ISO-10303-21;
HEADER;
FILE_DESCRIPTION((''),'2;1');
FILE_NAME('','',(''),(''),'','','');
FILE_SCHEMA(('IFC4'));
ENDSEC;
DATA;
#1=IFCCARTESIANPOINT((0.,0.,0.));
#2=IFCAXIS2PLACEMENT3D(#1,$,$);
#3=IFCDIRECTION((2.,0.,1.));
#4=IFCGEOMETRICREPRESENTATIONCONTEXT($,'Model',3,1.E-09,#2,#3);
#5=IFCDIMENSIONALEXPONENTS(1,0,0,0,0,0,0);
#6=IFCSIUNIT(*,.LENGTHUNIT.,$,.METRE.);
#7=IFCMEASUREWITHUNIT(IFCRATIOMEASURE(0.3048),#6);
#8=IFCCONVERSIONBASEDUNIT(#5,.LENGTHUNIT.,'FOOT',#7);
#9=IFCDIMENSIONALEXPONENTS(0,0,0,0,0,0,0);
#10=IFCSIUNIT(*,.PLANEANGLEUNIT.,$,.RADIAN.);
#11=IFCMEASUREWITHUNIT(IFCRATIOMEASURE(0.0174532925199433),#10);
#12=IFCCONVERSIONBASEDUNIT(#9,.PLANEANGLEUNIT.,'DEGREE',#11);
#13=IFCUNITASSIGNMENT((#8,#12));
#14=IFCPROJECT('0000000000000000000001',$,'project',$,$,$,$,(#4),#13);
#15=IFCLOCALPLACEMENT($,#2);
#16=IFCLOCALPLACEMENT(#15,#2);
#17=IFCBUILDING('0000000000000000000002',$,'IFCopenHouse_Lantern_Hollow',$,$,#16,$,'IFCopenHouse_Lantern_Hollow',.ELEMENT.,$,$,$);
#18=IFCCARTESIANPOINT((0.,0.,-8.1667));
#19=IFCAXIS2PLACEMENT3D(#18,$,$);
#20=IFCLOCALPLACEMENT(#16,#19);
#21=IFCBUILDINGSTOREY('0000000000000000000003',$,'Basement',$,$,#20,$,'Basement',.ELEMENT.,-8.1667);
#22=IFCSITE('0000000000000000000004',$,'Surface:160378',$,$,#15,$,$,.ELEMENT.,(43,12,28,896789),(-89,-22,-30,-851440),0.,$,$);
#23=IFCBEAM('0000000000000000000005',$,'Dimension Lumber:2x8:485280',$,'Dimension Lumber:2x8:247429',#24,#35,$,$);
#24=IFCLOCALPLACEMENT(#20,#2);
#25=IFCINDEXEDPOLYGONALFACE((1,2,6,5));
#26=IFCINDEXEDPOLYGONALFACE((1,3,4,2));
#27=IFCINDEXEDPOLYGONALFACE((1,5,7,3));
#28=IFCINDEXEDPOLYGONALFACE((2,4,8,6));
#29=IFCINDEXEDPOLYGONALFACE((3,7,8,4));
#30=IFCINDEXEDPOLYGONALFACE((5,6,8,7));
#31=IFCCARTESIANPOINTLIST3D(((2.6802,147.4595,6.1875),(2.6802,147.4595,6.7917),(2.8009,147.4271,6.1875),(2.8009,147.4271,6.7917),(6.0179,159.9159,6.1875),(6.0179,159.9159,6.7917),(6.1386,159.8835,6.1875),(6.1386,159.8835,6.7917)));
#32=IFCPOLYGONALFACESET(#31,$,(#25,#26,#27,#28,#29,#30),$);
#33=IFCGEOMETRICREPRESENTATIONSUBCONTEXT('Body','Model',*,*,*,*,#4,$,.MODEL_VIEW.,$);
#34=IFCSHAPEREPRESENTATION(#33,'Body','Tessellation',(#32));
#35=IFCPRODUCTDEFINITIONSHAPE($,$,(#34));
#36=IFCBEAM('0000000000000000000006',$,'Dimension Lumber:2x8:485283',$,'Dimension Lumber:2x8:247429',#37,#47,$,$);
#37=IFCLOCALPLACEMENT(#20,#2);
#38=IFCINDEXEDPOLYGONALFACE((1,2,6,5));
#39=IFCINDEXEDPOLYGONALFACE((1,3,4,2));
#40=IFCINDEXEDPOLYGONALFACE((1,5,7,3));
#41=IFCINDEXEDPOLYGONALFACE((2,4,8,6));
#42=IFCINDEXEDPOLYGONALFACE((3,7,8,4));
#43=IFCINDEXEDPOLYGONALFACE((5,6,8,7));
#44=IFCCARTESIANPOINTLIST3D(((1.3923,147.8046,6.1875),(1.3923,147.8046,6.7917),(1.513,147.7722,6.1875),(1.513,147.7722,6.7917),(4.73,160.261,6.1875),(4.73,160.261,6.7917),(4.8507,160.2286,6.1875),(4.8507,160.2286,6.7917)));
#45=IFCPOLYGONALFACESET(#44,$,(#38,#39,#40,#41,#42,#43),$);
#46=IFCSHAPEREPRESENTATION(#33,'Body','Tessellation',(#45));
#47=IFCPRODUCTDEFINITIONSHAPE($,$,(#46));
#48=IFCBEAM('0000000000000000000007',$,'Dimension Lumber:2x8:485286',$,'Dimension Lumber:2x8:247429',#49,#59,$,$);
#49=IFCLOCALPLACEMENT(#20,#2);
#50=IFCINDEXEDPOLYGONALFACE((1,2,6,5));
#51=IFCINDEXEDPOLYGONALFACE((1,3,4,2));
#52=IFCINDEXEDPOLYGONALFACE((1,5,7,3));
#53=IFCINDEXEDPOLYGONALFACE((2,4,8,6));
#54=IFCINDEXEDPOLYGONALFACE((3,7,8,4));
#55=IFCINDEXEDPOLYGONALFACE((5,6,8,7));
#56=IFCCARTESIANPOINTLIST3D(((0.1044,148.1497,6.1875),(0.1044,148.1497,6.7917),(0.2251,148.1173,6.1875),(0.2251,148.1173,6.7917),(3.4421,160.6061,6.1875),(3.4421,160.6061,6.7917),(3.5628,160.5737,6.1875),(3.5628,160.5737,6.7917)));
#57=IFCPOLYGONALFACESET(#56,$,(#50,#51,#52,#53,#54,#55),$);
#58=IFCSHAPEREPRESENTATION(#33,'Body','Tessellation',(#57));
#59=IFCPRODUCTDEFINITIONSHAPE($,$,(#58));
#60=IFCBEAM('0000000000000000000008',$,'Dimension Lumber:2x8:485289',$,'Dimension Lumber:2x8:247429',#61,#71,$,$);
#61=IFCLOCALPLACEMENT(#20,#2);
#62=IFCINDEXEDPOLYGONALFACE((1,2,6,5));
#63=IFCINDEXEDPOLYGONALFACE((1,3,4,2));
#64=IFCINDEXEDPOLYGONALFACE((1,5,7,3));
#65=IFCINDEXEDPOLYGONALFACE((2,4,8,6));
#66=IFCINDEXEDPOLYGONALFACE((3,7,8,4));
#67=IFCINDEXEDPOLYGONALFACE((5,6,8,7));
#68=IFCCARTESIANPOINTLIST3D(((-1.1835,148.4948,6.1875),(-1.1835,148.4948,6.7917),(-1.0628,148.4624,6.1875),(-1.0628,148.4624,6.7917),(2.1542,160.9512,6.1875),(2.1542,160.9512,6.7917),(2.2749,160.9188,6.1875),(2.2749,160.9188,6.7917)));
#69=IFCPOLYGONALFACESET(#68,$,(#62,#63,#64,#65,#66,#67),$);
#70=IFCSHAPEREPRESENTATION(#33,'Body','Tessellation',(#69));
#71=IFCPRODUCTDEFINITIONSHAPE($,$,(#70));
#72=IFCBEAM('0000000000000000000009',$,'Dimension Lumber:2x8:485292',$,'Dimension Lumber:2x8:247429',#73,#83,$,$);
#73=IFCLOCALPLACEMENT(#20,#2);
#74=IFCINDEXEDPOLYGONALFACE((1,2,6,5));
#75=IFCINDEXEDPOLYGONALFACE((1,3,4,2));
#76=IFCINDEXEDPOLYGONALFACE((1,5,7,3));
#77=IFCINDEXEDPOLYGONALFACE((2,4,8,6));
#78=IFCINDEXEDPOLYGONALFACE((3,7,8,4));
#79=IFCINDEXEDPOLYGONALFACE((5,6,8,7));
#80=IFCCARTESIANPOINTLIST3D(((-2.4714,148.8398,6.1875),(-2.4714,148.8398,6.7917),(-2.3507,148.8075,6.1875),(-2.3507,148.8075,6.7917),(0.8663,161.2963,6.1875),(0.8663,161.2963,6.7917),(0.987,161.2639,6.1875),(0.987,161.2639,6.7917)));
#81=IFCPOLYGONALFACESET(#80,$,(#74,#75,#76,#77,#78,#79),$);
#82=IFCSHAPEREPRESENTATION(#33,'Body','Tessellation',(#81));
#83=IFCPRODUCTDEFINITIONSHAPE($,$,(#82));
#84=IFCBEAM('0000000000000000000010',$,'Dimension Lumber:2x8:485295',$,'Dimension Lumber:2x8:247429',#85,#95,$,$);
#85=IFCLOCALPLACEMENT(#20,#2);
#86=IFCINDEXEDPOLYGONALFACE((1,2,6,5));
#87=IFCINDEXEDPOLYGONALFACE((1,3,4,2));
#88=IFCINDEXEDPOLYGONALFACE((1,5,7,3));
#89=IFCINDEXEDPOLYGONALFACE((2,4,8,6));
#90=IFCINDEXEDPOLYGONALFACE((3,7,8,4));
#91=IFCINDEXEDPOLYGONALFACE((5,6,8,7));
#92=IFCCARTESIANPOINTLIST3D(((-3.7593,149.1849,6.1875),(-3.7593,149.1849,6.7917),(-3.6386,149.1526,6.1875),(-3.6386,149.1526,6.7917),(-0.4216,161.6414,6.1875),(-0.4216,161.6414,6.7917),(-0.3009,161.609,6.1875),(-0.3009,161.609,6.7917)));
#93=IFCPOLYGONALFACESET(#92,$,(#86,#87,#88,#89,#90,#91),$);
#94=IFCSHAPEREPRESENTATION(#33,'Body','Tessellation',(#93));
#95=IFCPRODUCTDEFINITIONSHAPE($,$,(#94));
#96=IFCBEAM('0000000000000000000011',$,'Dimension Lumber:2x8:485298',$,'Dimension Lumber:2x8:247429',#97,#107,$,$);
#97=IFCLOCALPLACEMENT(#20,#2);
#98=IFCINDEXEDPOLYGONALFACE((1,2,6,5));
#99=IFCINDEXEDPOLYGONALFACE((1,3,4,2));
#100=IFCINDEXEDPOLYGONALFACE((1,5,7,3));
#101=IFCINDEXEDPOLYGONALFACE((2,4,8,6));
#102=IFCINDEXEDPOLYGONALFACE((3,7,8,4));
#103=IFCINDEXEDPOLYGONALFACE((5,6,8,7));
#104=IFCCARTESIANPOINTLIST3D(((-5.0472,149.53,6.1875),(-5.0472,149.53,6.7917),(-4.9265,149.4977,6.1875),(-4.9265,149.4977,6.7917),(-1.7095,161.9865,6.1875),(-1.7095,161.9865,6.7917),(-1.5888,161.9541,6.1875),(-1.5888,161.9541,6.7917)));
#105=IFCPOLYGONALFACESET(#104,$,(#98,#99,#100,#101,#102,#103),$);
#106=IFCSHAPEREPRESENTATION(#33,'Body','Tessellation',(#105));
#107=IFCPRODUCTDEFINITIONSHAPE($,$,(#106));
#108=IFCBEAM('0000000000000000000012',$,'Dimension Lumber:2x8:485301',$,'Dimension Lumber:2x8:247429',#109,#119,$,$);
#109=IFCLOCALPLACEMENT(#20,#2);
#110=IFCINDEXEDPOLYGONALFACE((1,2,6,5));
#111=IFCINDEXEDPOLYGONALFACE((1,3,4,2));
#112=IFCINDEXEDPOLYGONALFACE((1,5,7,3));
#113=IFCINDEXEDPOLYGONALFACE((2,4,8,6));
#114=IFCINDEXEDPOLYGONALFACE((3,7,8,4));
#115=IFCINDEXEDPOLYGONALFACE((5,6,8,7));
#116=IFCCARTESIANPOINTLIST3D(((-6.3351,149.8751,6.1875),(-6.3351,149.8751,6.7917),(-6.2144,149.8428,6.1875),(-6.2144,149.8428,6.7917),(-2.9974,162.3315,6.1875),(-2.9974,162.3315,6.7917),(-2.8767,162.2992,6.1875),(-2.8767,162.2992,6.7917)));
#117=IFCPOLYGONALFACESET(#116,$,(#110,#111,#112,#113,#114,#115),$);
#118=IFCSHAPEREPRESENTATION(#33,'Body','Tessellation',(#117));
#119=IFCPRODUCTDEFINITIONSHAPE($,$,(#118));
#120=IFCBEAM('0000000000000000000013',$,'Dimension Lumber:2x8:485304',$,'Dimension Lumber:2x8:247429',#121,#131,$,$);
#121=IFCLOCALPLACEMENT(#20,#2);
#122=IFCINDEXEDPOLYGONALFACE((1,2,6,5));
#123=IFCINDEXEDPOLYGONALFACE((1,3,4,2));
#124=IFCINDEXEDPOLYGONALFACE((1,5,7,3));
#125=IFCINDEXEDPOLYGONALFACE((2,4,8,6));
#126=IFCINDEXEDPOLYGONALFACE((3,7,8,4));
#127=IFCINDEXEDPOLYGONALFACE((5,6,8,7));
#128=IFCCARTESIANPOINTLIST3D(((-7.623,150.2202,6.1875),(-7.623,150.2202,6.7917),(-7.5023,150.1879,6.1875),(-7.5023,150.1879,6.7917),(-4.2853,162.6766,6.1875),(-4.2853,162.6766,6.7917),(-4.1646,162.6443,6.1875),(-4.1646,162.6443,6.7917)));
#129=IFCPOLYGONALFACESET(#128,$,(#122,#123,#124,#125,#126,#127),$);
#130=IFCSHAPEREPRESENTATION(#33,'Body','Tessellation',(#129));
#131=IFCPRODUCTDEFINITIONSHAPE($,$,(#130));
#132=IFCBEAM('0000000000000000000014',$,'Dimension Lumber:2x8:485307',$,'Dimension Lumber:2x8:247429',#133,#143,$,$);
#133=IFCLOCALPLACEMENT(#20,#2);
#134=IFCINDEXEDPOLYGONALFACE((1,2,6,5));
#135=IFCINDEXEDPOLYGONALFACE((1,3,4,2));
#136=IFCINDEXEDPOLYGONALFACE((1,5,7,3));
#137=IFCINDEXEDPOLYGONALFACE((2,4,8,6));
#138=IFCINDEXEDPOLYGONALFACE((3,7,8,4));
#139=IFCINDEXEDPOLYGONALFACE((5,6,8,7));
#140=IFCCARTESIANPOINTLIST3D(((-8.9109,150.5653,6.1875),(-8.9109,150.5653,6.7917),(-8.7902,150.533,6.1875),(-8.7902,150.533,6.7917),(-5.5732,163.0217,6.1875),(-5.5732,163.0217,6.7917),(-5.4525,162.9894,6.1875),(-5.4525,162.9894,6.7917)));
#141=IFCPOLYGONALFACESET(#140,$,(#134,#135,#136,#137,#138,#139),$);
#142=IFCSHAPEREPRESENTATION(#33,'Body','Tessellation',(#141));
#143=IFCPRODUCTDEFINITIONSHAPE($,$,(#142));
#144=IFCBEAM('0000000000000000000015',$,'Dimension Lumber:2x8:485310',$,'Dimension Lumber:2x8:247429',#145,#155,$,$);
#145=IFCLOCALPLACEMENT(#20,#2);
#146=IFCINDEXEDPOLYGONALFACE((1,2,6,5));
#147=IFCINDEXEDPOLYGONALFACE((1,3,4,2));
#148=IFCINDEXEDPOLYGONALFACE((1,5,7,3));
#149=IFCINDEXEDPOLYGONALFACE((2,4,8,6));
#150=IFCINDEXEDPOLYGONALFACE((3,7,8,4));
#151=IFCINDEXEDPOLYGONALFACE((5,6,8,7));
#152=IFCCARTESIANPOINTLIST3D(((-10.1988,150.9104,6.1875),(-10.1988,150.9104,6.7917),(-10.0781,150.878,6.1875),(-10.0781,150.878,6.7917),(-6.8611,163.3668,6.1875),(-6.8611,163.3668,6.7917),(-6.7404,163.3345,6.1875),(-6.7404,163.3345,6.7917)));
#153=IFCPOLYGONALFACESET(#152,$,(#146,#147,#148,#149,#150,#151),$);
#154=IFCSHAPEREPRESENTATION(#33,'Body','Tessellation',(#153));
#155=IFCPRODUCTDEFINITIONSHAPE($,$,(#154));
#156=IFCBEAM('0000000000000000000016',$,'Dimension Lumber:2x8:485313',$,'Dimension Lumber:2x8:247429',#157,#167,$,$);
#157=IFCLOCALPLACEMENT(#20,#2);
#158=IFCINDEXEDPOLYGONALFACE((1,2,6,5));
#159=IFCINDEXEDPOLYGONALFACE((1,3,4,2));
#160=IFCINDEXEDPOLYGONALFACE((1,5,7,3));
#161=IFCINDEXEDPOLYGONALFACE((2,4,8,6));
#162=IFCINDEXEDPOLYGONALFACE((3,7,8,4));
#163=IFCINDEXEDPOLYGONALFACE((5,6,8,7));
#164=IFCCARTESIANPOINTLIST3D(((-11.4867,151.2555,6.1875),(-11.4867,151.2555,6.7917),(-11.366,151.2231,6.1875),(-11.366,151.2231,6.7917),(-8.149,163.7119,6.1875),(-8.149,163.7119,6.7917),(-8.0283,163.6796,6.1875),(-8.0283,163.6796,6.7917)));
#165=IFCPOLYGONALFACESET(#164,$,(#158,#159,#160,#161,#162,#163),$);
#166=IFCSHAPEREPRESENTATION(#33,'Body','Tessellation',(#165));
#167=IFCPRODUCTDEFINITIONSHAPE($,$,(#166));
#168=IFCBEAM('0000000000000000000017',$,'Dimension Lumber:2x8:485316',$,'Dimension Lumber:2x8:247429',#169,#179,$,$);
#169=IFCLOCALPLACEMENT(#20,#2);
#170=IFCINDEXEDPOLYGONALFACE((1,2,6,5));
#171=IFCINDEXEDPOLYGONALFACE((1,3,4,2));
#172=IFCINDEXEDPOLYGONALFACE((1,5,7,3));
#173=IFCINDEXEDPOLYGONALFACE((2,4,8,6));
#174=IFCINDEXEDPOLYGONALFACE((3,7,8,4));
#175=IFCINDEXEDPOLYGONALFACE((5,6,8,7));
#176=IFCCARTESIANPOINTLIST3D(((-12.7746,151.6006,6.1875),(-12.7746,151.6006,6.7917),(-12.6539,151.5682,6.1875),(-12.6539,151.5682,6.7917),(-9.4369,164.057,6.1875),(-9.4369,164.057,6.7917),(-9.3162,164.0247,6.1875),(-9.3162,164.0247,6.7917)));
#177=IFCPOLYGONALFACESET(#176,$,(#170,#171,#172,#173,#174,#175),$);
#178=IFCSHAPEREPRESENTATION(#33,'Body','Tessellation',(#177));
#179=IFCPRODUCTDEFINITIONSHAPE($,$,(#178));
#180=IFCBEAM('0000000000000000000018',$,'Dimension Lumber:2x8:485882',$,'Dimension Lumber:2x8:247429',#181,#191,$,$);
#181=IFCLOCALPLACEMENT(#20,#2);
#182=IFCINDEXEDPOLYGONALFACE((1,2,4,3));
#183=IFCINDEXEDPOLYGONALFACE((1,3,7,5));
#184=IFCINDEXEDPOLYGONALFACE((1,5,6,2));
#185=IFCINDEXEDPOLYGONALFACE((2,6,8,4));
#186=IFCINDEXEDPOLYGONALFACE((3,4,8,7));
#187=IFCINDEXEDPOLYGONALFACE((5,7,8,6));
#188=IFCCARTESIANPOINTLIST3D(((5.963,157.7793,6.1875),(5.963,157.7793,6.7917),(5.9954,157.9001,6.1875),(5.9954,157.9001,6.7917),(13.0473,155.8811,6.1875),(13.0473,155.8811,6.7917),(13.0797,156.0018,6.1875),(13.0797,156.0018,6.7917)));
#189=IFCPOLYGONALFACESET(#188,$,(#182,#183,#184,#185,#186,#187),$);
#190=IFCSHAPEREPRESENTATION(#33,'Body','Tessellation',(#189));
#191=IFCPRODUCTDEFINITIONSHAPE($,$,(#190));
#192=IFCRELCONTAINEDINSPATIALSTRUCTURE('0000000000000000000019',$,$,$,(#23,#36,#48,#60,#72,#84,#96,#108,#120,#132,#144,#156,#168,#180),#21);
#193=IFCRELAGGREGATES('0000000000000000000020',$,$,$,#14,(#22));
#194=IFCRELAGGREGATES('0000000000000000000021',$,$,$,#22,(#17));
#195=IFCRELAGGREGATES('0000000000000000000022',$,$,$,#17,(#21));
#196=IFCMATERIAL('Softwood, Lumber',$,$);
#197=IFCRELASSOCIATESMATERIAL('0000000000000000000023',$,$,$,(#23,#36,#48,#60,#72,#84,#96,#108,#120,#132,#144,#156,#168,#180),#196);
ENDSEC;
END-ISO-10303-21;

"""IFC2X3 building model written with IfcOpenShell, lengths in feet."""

from ifc_helpers import new_model, entity, si_unit, converted_unit, direction, frame, frame_2d, origin, place, context, subcontext, project, spatial, rectangle, extrude, material, element, save


model = new_model("IFC2X3")

# Units and contexts
model_context = context("Model", 3, precision=1e-09, world=origin(), true_north=direction((2.0, 0.0, 1.0)))
body_context = subcontext(model_context, "Body", "Model", "MODEL_VIEW")
ifc_project = project(units=[converted_unit("LENGTHUNIT", "FOOT", entity("IfcRatioMeasure", 0.3048), si_unit("LENGTHUNIT", "METRE"), dimensions=[1, 0, 0, 0, 0, 0, 0]), converted_unit("PLANEANGLEUNIT", "DEGREE", entity("IfcRatioMeasure", 0.0174532925199433), si_unit("PLANEANGLEUNIT", "RADIAN"), dimensions=[0, 0, 0, 0, 0, 0, 0])], contexts=[model_context])

# Site, building, storey
site_placement = place(None, origin())
site = spatial("IfcSite", under=ifc_project, at=site_placement, Name="Surface:160378", CompositionType="ELEMENT", RefLatitude=(43, 12, 28, 896789), RefLongitude=(-89, -22, -30, -851440), RefElevation=0.0)
building_placement = place(site_placement, origin())
building = spatial("IfcBuilding", under=site, at=building_placement, Name="IFCopenHouse_Lantern_Hollow", LongName="IFCopenHouse_Lantern_Hollow", CompositionType="ELEMENT")
storey_placement = place(building_placement, frame((0.0, 0.0, -8.1667)))
storey = spatial("IfcBuildingStorey", under=building, at=storey_placement, Name="Basement", LongName="Basement", CompositionType="ELEMENT", Elevation=-8.1667)

# Beams
ifc_material_1 = material(Name="Softwood, Lumber")
for number, where, z_axis, x_axis, name in (
    (1, (6.0783, 159.8997, 8.1667), (0.0, 0.0, 1.0), (-0.258819, -0.965926, 0.0), "Dimension Lumber:2x8:485280"),
    (2, (4.7904, 160.2448, 8.1667), (0.0, 0.0, 1.0), (-0.258819, -0.965926, 0.0), "Dimension Lumber:2x8:485283"),
):
    element("IfcBeam", number, at=place(storey_placement, frame(where, z_axis=z_axis, x_axis=x_axis)), inside=storey, material=ifc_material_1, Name=name, ObjectType="Dimension Lumber:2x8:247429", context=body_context, shape_type="SweptSolid", body=[
        extrude(rectangle(XDim=0.6042, YDim=0.125, at=frame_2d((0.0, 0.0), x_axis=(1.0, 0.0))), frame((0.0, 0.0, -1.6771), z_axis=(1.0, 0.0, 0.0), x_axis=(0.0, 0.0, -1.0)), (0.0, 0.0, 1.0), 12.8958),
    ])
beam_1_placement = place(storey_placement, frame((3.5025, 160.5899, 8.1667), z_axis=(0.0, 0.0, 1.0), x_axis=(-0.258819, -0.965926, 0.0)))
element("IfcBeam", 3, at=beam_1_placement, inside=storey, material=ifc_material_1, Name="Dimension Lumber:2x8:485286", ObjectType="Dimension Lumber:2x8:247429", context=body_context, shape_type="SweptSolid", body=[
    extrude(rectangle(XDim=0.6042, YDim=0.125, at=frame_2d((0.0, 0.0), x_axis=(1.0, 0.0))), frame((0.0, 0.0, -1.6771), z_axis=(1.0, 0.0, 0.0), x_axis=(0.0, 0.0, -1.0)), (0.0, 0.0, 1.0), 12.8958),
])
beam_2_placement = place(storey_placement, frame((2.2146, 160.935, 8.1667), z_axis=(0.0, 0.0, 1.0), x_axis=(-0.258819, -0.965926, 0.0)))
element("IfcBeam", 4, at=beam_2_placement, inside=storey, material=ifc_material_1, Name="Dimension Lumber:2x8:485289", ObjectType="Dimension Lumber:2x8:247429", context=body_context, shape_type="SweptSolid", body=[
    extrude(rectangle(XDim=0.6042, YDim=0.125, at=frame_2d((0.0, 0.0), x_axis=(1.0, 0.0))), frame((0.0, 0.0, -1.6771), z_axis=(1.0, 0.0, 0.0), x_axis=(0.0, 0.0, -1.0)), (0.0, 0.0, 1.0), 12.8958),
])
beam_3_placement = place(storey_placement, frame((0.9267, 161.2801, 8.1667), z_axis=(0.0, 0.0, 1.0), x_axis=(-0.258819, -0.965926, 0.0)))
element("IfcBeam", 5, at=beam_3_placement, inside=storey, material=ifc_material_1, Name="Dimension Lumber:2x8:485292", ObjectType="Dimension Lumber:2x8:247429", context=body_context, shape_type="SweptSolid", body=[
    extrude(rectangle(XDim=0.6042, YDim=0.125, at=frame_2d((0.0, 0.0), x_axis=(1.0, 0.0))), frame((0.0, 0.0, -1.6771), z_axis=(1.0, 0.0, 0.0), x_axis=(0.0, 0.0, -1.0)), (0.0, 0.0, 1.0), 12.8958),
])
beam_4_placement = place(storey_placement, frame((-0.3612, 161.6252, 8.1667), z_axis=(0.0, 0.0, 1.0), x_axis=(-0.258819, -0.965926, 0.0)))
element("IfcBeam", 6, at=beam_4_placement, inside=storey, material=ifc_material_1, Name="Dimension Lumber:2x8:485295", ObjectType="Dimension Lumber:2x8:247429", context=body_context, shape_type="SweptSolid", body=[
    extrude(rectangle(XDim=0.6042, YDim=0.125, at=frame_2d((0.0, 0.0), x_axis=(1.0, 0.0))), frame((0.0, 0.0, -1.6771), z_axis=(1.0, 0.0, 0.0), x_axis=(0.0, 0.0, -1.0)), (0.0, 0.0, 1.0), 12.8958),
])
beam_5_placement = place(storey_placement, frame((-1.6491, 161.9703, 8.1667), z_axis=(0.0, 0.0, 1.0), x_axis=(-0.258819, -0.965926, 0.0)))
element("IfcBeam", 7, at=beam_5_placement, inside=storey, material=ifc_material_1, Name="Dimension Lumber:2x8:485298", ObjectType="Dimension Lumber:2x8:247429", context=body_context, shape_type="SweptSolid", body=[
    extrude(rectangle(XDim=0.6042, YDim=0.125, at=frame_2d((0.0, 0.0), x_axis=(1.0, 0.0))), frame((0.0, 0.0, -1.6771), z_axis=(1.0, 0.0, 0.0), x_axis=(0.0, 0.0, -1.0)), (0.0, 0.0, 1.0), 12.8958),
])
beam_6_placement = place(storey_placement, frame((-2.937, 162.3154, 8.1667), z_axis=(0.0, 0.0, 1.0), x_axis=(-0.258819, -0.965926, 0.0)))
element("IfcBeam", 8, at=beam_6_placement, inside=storey, material=ifc_material_1, Name="Dimension Lumber:2x8:485301", ObjectType="Dimension Lumber:2x8:247429", context=body_context, shape_type="SweptSolid", body=[
    extrude(rectangle(XDim=0.6042, YDim=0.125, at=frame_2d((0.0, 0.0), x_axis=(1.0, 0.0))), frame((0.0, 0.0, -1.6771), z_axis=(1.0, 0.0, 0.0), x_axis=(0.0, 0.0, -1.0)), (0.0, 0.0, 1.0), 12.8958),
])
beam_7_placement = place(storey_placement, frame((-4.2249, 162.6605, 8.1667), z_axis=(0.0, 0.0, 1.0), x_axis=(-0.258819, -0.965926, 0.0)))
element("IfcBeam", 9, at=beam_7_placement, inside=storey, material=ifc_material_1, Name="Dimension Lumber:2x8:485304", ObjectType="Dimension Lumber:2x8:247429", context=body_context, shape_type="SweptSolid", body=[
    extrude(rectangle(XDim=0.6042, YDim=0.125, at=frame_2d((0.0, 0.0), x_axis=(1.0, 0.0))), frame((0.0, 0.0, -1.6771), z_axis=(1.0, 0.0, 0.0), x_axis=(0.0, 0.0, -1.0)), (0.0, 0.0, 1.0), 12.8958),
])
beam_8_placement = place(storey_placement, frame((-5.5129, 163.0056, 8.1667), z_axis=(0.0, 0.0, 1.0), x_axis=(-0.258819, -0.965926, 0.0)))
element("IfcBeam", 10, at=beam_8_placement, inside=storey, material=ifc_material_1, Name="Dimension Lumber:2x8:485307", ObjectType="Dimension Lumber:2x8:247429", context=body_context, shape_type="SweptSolid", body=[
    extrude(rectangle(XDim=0.6042, YDim=0.125, at=frame_2d((0.0, 0.0), x_axis=(1.0, 0.0))), frame((0.0, 0.0, -1.6771), z_axis=(1.0, 0.0, 0.0), x_axis=(0.0, 0.0, -1.0)), (0.0, 0.0, 1.0), 12.8958),
])
for number, where, z_axis, x_axis, name in (
    (11, (-6.8008, 163.3506, 8.1667), (0.0, 0.0, 1.0), (-0.258819, -0.965926, 0.0), "Dimension Lumber:2x8:485310"),
    (12, (-8.0887, 163.6957, 8.1667), (0.0, 0.0, 1.0), (-0.258819, -0.965926, 0.0), "Dimension Lumber:2x8:485313"),
):
    element("IfcBeam", number, at=place(storey_placement, frame(where, z_axis=z_axis, x_axis=x_axis)), inside=storey, material=ifc_material_1, Name=name, ObjectType="Dimension Lumber:2x8:247429", context=body_context, shape_type="SweptSolid", body=[
        extrude(rectangle(XDim=0.6042, YDim=0.125, at=frame_2d((0.0, 0.0), x_axis=(1.0, 0.0))), frame((0.0, 0.0, -1.6771), z_axis=(1.0, 0.0, 0.0), x_axis=(0.0, 0.0, -1.0)), (0.0, 0.0, 1.0), 12.8958),
    ])
beam_9_placement = place(storey_placement, frame((-9.3766, 164.0408, 8.1667), z_axis=(0.0, 0.0, 1.0), x_axis=(-0.258819, -0.965926, 0.0)))
element("IfcBeam", 13, at=beam_9_placement, inside=storey, material=ifc_material_1, Name="Dimension Lumber:2x8:485316", ObjectType="Dimension Lumber:2x8:247429", context=body_context, shape_type="SweptSolid", body=[
    extrude(rectangle(XDim=0.6042, YDim=0.125, at=frame_2d((0.0, 0.0), x_axis=(1.0, 0.0))), frame((0.0, 0.0, -1.6771), z_axis=(1.0, 0.0, 0.0), x_axis=(0.0, 0.0, -1.0)), (0.0, 0.0, 1.0), 12.8958),
])
beam_10_placement = place(storey_placement, frame((5.9792, 157.8397, 8.1667), z_axis=(0.0, 0.0, 1.0), x_axis=(0.965926, -0.258819, 0.0)))
element("IfcBeam", 14, at=beam_10_placement, inside=storey, material=ifc_material_1, Name="Dimension Lumber:2x8:485882", ObjectType="Dimension Lumber:2x8:247429", context=body_context, shape_type="SweptSolid", body=[
    extrude(rectangle(XDim=0.6042, YDim=0.125, at=frame_2d((0.0, 0.0), x_axis=(1.0, 0.0))), frame((0.0, 0.0, -1.6771), z_axis=(1.0, 0.0, 0.0), x_axis=(0.0, 0.0, -1.0)), (0.0, 0.0, 1.0), 7.3342),
])

save(model, "model.ifc")
